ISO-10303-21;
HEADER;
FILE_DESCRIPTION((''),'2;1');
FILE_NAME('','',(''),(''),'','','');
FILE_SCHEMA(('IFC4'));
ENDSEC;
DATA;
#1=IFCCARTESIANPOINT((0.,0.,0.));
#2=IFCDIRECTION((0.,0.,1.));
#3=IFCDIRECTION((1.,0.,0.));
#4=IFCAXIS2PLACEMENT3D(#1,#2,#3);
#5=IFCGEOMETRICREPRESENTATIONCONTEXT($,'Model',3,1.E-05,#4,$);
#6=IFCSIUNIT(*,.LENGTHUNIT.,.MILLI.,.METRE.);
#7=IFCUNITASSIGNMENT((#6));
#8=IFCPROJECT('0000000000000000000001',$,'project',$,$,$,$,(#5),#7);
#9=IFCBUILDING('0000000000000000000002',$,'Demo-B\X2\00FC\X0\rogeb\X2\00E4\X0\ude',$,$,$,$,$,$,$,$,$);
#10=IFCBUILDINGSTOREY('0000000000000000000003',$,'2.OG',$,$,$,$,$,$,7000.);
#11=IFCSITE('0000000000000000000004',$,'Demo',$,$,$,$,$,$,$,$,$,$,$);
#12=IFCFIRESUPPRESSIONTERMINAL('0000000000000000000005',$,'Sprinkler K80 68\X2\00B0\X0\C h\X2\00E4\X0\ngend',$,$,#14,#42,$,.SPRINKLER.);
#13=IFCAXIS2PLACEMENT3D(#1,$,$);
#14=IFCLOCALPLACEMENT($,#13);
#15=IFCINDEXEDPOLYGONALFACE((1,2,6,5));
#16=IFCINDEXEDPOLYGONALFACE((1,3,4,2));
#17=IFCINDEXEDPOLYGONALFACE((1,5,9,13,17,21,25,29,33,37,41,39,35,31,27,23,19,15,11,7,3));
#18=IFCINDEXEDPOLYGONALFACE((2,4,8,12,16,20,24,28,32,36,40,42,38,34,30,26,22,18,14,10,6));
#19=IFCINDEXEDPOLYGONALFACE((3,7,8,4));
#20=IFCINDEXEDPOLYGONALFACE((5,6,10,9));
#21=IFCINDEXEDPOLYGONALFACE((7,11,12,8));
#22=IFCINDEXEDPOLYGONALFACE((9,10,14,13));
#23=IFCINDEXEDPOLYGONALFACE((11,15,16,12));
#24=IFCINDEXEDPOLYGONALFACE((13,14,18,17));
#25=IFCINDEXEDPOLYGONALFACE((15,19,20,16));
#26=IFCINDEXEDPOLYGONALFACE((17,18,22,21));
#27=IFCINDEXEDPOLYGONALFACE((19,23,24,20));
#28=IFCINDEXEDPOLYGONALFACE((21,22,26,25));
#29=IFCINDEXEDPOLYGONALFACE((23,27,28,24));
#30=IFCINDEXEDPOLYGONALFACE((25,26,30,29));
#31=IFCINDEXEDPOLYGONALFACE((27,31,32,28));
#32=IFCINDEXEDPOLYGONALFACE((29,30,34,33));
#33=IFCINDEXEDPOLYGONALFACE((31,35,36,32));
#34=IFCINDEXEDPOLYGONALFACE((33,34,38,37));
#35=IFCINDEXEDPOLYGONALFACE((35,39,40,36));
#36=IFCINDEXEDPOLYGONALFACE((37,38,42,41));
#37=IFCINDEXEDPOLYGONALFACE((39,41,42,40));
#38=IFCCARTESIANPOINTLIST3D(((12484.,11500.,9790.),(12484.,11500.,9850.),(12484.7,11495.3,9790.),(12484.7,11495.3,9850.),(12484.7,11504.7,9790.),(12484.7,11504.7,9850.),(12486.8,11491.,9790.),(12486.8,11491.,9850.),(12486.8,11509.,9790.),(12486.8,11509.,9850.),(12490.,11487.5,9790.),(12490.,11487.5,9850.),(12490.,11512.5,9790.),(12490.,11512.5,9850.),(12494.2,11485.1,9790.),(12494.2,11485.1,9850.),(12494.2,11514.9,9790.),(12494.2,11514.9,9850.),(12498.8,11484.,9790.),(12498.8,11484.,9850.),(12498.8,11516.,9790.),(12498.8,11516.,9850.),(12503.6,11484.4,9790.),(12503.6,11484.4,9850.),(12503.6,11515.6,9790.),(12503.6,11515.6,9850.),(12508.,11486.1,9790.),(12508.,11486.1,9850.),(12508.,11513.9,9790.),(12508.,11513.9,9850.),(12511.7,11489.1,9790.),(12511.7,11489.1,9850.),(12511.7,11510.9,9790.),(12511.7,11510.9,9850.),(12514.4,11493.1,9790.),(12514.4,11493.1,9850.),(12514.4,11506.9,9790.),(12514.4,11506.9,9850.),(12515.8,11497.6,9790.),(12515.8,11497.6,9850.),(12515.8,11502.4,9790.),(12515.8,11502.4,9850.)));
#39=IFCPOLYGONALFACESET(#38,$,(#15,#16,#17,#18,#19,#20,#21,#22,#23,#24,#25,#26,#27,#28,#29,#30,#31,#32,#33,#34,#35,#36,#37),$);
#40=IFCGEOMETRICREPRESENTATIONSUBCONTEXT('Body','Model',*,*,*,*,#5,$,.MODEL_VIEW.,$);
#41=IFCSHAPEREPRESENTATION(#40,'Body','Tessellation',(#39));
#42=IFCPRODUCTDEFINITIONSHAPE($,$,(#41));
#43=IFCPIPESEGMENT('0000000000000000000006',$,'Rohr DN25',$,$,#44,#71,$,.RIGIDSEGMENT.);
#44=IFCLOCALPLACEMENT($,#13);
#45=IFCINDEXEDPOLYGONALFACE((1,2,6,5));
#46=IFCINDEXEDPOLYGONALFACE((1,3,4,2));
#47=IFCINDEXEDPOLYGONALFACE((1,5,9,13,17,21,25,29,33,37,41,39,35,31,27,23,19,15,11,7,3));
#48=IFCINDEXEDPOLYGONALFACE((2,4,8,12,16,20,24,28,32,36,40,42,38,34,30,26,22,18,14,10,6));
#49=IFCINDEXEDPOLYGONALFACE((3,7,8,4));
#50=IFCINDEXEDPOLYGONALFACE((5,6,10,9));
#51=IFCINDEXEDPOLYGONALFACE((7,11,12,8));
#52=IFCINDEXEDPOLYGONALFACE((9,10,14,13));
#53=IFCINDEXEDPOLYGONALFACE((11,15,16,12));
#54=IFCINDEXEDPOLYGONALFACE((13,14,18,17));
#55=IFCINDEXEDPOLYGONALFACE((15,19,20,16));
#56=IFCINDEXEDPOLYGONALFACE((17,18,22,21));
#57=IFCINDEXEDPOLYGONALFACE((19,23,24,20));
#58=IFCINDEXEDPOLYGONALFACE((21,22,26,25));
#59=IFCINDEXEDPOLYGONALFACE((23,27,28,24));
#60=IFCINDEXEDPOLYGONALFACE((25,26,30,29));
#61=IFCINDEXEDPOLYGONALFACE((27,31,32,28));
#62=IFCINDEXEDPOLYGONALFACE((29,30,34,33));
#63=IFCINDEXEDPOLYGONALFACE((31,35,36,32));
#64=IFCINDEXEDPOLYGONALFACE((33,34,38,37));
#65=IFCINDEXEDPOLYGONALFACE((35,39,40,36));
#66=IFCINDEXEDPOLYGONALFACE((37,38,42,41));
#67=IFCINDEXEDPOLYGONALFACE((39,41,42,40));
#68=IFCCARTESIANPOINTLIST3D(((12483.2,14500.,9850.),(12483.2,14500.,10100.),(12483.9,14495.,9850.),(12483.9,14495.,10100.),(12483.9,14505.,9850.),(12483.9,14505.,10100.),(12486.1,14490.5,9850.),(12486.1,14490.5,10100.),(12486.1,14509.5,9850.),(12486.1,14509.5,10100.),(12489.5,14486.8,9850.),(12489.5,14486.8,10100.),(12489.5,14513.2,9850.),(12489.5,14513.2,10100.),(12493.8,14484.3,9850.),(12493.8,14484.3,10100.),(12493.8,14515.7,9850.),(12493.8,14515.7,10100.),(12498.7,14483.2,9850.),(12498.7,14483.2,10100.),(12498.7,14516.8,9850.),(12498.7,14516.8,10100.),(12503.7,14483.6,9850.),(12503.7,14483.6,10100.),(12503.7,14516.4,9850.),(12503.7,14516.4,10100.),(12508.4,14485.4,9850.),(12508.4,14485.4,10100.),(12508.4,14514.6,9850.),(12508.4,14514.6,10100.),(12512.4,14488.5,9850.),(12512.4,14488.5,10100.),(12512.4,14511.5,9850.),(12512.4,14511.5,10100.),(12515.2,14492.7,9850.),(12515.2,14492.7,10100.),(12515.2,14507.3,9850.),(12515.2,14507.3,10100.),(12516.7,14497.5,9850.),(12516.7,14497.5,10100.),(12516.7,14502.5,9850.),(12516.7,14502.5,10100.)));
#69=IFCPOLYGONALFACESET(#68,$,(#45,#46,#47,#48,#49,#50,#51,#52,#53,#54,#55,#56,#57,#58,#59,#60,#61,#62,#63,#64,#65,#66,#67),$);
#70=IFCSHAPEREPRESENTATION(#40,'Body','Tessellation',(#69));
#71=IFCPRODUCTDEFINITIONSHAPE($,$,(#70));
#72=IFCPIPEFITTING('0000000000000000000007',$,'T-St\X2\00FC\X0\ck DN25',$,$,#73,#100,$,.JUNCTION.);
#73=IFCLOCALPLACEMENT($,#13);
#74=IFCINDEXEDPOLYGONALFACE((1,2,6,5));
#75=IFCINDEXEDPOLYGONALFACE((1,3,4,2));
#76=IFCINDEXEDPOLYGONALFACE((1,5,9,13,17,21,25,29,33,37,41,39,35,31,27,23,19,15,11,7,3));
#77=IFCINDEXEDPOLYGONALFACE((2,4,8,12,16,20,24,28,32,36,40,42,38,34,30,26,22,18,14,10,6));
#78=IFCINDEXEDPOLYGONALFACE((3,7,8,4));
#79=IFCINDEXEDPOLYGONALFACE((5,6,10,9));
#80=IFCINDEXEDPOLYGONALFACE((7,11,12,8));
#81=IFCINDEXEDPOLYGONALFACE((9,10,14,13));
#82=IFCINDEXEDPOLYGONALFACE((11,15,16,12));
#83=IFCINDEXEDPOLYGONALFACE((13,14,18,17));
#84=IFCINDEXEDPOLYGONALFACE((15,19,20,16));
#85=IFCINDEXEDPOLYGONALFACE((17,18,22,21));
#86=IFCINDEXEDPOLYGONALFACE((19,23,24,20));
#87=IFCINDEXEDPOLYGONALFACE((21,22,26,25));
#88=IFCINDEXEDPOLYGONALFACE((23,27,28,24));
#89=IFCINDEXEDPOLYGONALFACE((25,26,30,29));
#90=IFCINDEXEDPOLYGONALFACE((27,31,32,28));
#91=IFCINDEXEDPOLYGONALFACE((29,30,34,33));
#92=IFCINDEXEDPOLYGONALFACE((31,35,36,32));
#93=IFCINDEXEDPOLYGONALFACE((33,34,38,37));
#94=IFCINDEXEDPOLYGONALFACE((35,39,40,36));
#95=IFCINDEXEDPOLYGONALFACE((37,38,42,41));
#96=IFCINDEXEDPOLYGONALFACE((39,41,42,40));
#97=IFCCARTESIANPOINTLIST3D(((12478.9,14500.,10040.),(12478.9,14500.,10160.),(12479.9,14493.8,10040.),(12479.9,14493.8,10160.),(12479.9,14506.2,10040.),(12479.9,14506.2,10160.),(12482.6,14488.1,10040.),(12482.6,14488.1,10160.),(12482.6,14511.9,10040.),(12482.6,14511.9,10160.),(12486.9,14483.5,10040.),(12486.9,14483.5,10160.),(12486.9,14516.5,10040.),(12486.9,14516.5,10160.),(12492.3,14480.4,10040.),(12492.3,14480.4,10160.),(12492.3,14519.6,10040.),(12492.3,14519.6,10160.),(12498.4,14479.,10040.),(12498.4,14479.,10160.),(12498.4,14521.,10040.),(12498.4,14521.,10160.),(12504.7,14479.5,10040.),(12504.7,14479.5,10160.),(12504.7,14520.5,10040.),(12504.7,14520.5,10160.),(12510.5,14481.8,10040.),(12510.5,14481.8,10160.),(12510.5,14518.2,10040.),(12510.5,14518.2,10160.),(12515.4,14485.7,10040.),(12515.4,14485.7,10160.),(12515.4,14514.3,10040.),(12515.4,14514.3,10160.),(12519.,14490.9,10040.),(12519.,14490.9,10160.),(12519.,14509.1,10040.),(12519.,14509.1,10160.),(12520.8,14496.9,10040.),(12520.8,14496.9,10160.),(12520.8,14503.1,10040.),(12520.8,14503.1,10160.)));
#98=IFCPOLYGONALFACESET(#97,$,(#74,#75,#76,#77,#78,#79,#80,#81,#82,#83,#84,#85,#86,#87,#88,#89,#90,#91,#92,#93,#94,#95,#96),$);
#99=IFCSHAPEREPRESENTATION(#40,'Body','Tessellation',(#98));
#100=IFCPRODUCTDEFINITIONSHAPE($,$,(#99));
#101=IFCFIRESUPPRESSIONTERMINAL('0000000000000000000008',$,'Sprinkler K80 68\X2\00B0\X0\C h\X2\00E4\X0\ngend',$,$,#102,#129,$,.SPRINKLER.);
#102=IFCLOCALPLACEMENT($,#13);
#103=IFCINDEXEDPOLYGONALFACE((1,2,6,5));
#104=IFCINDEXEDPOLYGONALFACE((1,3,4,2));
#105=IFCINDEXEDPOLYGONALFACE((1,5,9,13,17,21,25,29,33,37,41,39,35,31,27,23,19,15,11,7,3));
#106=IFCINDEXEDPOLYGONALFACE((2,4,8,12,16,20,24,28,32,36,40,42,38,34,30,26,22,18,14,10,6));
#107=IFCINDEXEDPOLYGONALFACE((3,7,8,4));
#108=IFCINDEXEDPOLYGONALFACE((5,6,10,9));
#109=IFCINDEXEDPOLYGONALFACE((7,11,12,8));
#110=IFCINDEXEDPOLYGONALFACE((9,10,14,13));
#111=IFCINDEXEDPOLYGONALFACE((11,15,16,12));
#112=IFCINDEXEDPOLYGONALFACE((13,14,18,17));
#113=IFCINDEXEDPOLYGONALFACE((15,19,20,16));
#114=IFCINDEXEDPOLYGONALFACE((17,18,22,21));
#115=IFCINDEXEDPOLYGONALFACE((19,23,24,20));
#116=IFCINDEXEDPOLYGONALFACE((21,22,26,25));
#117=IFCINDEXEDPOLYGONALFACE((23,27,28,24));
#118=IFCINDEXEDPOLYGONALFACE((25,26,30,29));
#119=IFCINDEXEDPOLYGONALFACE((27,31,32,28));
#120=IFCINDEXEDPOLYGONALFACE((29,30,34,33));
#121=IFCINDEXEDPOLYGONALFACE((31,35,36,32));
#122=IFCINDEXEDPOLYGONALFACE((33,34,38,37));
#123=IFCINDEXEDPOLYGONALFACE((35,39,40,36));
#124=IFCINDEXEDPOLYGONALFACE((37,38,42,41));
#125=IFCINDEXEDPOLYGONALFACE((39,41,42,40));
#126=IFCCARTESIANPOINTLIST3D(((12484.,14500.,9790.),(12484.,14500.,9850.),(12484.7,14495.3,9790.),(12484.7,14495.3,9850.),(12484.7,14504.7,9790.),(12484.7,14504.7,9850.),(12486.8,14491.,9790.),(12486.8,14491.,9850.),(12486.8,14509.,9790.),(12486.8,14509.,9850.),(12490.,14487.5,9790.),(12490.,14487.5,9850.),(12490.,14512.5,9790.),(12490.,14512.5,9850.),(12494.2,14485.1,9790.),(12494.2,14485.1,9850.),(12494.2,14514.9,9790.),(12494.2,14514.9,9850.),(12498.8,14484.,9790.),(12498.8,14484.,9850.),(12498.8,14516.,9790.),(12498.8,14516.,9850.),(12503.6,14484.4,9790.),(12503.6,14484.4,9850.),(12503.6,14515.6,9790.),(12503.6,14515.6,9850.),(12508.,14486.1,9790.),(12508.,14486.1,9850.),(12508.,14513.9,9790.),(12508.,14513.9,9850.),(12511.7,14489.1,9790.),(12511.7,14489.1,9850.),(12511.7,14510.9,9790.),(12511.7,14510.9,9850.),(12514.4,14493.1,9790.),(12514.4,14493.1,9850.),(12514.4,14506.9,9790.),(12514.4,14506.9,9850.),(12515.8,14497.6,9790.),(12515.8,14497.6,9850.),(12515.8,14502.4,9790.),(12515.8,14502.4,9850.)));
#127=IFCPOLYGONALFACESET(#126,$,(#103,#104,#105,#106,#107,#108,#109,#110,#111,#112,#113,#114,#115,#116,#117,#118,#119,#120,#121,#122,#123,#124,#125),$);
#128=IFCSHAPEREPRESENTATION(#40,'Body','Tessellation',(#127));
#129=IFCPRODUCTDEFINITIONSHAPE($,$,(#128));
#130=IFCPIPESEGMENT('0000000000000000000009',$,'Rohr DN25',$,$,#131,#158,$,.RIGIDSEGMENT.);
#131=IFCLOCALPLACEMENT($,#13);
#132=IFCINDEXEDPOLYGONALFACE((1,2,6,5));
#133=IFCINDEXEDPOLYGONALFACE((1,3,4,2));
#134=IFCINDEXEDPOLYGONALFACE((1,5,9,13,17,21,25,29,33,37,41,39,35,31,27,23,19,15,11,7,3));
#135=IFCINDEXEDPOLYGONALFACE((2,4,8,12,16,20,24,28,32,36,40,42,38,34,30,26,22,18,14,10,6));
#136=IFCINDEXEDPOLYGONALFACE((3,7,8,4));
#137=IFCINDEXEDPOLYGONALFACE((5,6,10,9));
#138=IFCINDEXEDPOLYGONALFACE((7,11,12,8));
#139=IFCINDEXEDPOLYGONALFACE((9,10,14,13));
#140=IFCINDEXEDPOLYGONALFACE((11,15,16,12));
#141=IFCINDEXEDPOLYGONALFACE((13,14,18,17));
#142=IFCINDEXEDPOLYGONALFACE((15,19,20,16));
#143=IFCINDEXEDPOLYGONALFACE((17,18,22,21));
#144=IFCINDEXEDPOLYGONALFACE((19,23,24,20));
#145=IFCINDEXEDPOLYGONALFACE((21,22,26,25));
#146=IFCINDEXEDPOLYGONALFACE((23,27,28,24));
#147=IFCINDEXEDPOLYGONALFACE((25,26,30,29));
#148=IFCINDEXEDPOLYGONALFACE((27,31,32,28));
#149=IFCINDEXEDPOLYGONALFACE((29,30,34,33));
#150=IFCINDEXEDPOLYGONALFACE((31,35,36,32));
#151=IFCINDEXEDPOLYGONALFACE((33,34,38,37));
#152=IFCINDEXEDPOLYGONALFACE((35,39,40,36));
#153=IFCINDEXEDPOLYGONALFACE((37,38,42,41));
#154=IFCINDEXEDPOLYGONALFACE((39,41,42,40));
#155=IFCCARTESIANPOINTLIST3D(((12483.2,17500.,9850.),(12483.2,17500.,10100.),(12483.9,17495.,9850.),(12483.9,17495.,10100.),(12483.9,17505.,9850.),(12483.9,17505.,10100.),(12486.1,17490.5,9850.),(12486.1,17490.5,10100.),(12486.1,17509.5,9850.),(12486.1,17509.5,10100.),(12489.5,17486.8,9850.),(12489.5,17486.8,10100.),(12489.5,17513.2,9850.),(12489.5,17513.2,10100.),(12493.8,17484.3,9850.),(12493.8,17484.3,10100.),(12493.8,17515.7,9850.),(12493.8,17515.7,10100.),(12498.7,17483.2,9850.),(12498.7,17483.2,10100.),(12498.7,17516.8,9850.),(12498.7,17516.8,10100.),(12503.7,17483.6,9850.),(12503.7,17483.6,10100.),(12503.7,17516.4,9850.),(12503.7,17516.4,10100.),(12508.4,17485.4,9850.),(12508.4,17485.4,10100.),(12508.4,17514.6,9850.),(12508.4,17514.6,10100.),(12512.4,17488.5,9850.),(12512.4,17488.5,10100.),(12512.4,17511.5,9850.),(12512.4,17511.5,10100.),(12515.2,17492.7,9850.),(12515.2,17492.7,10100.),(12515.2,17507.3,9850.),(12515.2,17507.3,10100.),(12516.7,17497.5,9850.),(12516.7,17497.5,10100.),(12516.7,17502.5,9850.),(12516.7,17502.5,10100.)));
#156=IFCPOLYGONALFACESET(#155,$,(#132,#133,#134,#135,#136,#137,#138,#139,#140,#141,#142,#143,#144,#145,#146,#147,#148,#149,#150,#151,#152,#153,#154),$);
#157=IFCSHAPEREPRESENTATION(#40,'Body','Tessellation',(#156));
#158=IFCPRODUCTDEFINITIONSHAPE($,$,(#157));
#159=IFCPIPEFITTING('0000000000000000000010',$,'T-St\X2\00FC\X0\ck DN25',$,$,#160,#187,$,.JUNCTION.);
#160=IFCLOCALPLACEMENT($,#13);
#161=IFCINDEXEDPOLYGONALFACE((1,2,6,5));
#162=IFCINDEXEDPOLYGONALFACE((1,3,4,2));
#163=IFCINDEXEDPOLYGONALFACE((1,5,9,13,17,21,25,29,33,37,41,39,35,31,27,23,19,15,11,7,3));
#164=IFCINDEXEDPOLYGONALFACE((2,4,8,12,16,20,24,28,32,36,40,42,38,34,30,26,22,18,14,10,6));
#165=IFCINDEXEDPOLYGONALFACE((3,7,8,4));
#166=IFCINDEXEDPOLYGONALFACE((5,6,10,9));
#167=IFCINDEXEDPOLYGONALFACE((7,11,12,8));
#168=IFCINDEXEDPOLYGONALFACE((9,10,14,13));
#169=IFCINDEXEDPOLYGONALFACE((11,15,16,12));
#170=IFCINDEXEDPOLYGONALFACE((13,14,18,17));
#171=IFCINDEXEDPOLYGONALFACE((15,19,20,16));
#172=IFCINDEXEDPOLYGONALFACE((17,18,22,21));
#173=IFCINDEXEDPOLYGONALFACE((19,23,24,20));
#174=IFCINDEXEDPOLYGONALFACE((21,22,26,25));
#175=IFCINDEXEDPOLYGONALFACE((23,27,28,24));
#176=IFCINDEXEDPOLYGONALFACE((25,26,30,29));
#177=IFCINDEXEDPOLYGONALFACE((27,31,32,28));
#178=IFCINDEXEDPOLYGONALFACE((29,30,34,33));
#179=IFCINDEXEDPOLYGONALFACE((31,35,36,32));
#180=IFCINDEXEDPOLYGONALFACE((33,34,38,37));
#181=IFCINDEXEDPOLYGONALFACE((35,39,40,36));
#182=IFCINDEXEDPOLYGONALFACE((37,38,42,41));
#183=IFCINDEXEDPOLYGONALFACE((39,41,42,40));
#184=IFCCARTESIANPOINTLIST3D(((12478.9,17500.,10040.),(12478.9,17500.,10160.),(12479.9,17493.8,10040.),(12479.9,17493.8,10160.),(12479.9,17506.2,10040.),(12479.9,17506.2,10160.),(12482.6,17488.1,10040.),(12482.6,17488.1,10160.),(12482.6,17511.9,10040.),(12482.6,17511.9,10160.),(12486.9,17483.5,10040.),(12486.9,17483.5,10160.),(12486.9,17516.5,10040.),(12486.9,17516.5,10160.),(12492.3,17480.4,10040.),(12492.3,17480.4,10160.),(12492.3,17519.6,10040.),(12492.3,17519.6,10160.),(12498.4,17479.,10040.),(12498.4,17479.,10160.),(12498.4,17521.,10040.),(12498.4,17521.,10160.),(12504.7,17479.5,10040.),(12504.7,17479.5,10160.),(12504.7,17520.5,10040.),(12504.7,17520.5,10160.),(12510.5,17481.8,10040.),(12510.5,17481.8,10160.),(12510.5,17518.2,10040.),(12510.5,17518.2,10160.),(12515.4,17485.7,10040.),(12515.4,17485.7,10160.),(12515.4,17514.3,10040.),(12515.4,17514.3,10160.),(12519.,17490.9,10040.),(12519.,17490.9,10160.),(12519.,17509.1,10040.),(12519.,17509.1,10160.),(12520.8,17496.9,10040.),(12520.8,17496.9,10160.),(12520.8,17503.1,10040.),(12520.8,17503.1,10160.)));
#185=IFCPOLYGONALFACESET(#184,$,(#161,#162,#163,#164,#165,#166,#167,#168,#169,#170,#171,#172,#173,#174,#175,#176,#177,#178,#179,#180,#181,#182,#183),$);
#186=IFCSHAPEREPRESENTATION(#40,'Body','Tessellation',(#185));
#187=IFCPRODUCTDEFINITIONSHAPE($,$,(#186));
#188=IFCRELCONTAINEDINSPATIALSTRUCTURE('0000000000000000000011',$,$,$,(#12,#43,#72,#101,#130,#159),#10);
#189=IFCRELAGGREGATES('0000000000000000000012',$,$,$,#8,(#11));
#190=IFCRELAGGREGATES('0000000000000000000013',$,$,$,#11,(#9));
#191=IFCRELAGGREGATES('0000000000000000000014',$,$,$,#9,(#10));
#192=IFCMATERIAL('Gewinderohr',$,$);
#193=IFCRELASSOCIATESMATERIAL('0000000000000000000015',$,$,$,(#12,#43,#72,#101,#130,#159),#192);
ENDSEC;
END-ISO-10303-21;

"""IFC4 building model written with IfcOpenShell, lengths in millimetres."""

from ifc_helpers import new_model, si_unit, frame, origin_with_axes, place, context, subcontext, project, spatial, circle, extrude, material, element, save


model = new_model("IFC4")

# Units and contexts
model_context = context("Model", 3, precision=1e-05, world=origin_with_axes())
body_context = subcontext(model_context, "Body", "Model", "MODEL_VIEW")
ifc_project = project(units=[si_unit("LENGTHUNIT", "METRE", prefix="MILLI")], contexts=[model_context])

# Site, building, storey
site = spatial("IfcSite", under=ifc_project, Name="Demo")
building = spatial("IfcBuilding", under=site, Name="Demo-Bürogebäude")
storey = spatial("IfcBuildingStorey", under=building, Name="2.OG", Elevation=7000.0)

# Shared definitions
ifc_material_1 = material(Name="Gewinderohr")

# Fire suppression terminal
fire_suppression_terminal_1_placement = place(None, frame((12500.0, 11500.0, 9850.0), z_axis=(0.0, 0.0, -1.0), x_axis=(-1.0, 0.0, 0.0)))
element("IfcFireSuppressionTerminal", 1, at=fire_suppression_terminal_1_placement, inside=storey, material=ifc_material_1, Name="Sprinkler K80 68°C hängend", PredefinedType="SPRINKLER", context=body_context, shape_type="SweptSolid", body=[
    extrude(circle(Radius=16.0), origin_with_axes(), (0.0, 0.0, 1.0), 60.0),
])

# Pipe segment
pipe_segment_1_placement = place(None, frame((12500.0, 14500.0, 10100.0), z_axis=(0.0, 0.0, -1.0), x_axis=(-1.0, 0.0, 0.0)))
element("IfcPipeSegment", 2, at=pipe_segment_1_placement, inside=storey, material=ifc_material_1, Name="Rohr DN25", PredefinedType="RIGIDSEGMENT", context=body_context, shape_type="SweptSolid", body=[
    extrude(circle(Radius=16.9), origin_with_axes(), (0.0, 0.0, 1.0), 250.0),
])

# Pipe fitting
pipe_fitting_1_placement = place(None, frame((12500.0, 14500.0, 10160.0), z_axis=(0.0, 0.0, -1.0), x_axis=(-1.0, 0.0, 0.0)))
element("IfcPipeFitting", 3, at=pipe_fitting_1_placement, inside=storey, material=ifc_material_1, Name="T-Stück DN25", PredefinedType="JUNCTION", context=body_context, shape_type="SweptSolid", body=[
    extrude(circle(Radius=21.1), origin_with_axes(), (0.0, 0.0, 1.0), 120.0),
])

# Fire suppression terminal
fire_suppression_terminal_2_placement = place(None, frame((12500.0, 14500.0, 9850.0), z_axis=(0.0, 0.0, -1.0), x_axis=(-1.0, 0.0, 0.0)))
element("IfcFireSuppressionTerminal", 4, at=fire_suppression_terminal_2_placement, inside=storey, material=ifc_material_1, Name="Sprinkler K80 68°C hängend", PredefinedType="SPRINKLER", context=body_context, shape_type="SweptSolid", body=[
    extrude(circle(Radius=16.0), origin_with_axes(), (0.0, 0.0, 1.0), 60.0),
])

# Pipe segment
pipe_segment_2_placement = place(None, frame((12500.0, 17500.0, 10100.0), z_axis=(0.0, 0.0, -1.0), x_axis=(-1.0, 0.0, 0.0)))
element("IfcPipeSegment", 5, at=pipe_segment_2_placement, inside=storey, material=ifc_material_1, Name="Rohr DN25", PredefinedType="RIGIDSEGMENT", context=body_context, shape_type="SweptSolid", body=[
    extrude(circle(Radius=16.9), origin_with_axes(), (0.0, 0.0, 1.0), 250.0),
])

# Pipe fitting
pipe_fitting_2_placement = place(None, frame((12500.0, 17500.0, 10160.0), z_axis=(0.0, 0.0, -1.0), x_axis=(-1.0, 0.0, 0.0)))
element("IfcPipeFitting", 6, at=pipe_fitting_2_placement, inside=storey, material=ifc_material_1, Name="T-Stück DN25", PredefinedType="JUNCTION", context=body_context, shape_type="SweptSolid", body=[
    extrude(circle(Radius=21.1), origin_with_axes(), (0.0, 0.0, 1.0), 120.0),
])

save(model, "model.ifc")
